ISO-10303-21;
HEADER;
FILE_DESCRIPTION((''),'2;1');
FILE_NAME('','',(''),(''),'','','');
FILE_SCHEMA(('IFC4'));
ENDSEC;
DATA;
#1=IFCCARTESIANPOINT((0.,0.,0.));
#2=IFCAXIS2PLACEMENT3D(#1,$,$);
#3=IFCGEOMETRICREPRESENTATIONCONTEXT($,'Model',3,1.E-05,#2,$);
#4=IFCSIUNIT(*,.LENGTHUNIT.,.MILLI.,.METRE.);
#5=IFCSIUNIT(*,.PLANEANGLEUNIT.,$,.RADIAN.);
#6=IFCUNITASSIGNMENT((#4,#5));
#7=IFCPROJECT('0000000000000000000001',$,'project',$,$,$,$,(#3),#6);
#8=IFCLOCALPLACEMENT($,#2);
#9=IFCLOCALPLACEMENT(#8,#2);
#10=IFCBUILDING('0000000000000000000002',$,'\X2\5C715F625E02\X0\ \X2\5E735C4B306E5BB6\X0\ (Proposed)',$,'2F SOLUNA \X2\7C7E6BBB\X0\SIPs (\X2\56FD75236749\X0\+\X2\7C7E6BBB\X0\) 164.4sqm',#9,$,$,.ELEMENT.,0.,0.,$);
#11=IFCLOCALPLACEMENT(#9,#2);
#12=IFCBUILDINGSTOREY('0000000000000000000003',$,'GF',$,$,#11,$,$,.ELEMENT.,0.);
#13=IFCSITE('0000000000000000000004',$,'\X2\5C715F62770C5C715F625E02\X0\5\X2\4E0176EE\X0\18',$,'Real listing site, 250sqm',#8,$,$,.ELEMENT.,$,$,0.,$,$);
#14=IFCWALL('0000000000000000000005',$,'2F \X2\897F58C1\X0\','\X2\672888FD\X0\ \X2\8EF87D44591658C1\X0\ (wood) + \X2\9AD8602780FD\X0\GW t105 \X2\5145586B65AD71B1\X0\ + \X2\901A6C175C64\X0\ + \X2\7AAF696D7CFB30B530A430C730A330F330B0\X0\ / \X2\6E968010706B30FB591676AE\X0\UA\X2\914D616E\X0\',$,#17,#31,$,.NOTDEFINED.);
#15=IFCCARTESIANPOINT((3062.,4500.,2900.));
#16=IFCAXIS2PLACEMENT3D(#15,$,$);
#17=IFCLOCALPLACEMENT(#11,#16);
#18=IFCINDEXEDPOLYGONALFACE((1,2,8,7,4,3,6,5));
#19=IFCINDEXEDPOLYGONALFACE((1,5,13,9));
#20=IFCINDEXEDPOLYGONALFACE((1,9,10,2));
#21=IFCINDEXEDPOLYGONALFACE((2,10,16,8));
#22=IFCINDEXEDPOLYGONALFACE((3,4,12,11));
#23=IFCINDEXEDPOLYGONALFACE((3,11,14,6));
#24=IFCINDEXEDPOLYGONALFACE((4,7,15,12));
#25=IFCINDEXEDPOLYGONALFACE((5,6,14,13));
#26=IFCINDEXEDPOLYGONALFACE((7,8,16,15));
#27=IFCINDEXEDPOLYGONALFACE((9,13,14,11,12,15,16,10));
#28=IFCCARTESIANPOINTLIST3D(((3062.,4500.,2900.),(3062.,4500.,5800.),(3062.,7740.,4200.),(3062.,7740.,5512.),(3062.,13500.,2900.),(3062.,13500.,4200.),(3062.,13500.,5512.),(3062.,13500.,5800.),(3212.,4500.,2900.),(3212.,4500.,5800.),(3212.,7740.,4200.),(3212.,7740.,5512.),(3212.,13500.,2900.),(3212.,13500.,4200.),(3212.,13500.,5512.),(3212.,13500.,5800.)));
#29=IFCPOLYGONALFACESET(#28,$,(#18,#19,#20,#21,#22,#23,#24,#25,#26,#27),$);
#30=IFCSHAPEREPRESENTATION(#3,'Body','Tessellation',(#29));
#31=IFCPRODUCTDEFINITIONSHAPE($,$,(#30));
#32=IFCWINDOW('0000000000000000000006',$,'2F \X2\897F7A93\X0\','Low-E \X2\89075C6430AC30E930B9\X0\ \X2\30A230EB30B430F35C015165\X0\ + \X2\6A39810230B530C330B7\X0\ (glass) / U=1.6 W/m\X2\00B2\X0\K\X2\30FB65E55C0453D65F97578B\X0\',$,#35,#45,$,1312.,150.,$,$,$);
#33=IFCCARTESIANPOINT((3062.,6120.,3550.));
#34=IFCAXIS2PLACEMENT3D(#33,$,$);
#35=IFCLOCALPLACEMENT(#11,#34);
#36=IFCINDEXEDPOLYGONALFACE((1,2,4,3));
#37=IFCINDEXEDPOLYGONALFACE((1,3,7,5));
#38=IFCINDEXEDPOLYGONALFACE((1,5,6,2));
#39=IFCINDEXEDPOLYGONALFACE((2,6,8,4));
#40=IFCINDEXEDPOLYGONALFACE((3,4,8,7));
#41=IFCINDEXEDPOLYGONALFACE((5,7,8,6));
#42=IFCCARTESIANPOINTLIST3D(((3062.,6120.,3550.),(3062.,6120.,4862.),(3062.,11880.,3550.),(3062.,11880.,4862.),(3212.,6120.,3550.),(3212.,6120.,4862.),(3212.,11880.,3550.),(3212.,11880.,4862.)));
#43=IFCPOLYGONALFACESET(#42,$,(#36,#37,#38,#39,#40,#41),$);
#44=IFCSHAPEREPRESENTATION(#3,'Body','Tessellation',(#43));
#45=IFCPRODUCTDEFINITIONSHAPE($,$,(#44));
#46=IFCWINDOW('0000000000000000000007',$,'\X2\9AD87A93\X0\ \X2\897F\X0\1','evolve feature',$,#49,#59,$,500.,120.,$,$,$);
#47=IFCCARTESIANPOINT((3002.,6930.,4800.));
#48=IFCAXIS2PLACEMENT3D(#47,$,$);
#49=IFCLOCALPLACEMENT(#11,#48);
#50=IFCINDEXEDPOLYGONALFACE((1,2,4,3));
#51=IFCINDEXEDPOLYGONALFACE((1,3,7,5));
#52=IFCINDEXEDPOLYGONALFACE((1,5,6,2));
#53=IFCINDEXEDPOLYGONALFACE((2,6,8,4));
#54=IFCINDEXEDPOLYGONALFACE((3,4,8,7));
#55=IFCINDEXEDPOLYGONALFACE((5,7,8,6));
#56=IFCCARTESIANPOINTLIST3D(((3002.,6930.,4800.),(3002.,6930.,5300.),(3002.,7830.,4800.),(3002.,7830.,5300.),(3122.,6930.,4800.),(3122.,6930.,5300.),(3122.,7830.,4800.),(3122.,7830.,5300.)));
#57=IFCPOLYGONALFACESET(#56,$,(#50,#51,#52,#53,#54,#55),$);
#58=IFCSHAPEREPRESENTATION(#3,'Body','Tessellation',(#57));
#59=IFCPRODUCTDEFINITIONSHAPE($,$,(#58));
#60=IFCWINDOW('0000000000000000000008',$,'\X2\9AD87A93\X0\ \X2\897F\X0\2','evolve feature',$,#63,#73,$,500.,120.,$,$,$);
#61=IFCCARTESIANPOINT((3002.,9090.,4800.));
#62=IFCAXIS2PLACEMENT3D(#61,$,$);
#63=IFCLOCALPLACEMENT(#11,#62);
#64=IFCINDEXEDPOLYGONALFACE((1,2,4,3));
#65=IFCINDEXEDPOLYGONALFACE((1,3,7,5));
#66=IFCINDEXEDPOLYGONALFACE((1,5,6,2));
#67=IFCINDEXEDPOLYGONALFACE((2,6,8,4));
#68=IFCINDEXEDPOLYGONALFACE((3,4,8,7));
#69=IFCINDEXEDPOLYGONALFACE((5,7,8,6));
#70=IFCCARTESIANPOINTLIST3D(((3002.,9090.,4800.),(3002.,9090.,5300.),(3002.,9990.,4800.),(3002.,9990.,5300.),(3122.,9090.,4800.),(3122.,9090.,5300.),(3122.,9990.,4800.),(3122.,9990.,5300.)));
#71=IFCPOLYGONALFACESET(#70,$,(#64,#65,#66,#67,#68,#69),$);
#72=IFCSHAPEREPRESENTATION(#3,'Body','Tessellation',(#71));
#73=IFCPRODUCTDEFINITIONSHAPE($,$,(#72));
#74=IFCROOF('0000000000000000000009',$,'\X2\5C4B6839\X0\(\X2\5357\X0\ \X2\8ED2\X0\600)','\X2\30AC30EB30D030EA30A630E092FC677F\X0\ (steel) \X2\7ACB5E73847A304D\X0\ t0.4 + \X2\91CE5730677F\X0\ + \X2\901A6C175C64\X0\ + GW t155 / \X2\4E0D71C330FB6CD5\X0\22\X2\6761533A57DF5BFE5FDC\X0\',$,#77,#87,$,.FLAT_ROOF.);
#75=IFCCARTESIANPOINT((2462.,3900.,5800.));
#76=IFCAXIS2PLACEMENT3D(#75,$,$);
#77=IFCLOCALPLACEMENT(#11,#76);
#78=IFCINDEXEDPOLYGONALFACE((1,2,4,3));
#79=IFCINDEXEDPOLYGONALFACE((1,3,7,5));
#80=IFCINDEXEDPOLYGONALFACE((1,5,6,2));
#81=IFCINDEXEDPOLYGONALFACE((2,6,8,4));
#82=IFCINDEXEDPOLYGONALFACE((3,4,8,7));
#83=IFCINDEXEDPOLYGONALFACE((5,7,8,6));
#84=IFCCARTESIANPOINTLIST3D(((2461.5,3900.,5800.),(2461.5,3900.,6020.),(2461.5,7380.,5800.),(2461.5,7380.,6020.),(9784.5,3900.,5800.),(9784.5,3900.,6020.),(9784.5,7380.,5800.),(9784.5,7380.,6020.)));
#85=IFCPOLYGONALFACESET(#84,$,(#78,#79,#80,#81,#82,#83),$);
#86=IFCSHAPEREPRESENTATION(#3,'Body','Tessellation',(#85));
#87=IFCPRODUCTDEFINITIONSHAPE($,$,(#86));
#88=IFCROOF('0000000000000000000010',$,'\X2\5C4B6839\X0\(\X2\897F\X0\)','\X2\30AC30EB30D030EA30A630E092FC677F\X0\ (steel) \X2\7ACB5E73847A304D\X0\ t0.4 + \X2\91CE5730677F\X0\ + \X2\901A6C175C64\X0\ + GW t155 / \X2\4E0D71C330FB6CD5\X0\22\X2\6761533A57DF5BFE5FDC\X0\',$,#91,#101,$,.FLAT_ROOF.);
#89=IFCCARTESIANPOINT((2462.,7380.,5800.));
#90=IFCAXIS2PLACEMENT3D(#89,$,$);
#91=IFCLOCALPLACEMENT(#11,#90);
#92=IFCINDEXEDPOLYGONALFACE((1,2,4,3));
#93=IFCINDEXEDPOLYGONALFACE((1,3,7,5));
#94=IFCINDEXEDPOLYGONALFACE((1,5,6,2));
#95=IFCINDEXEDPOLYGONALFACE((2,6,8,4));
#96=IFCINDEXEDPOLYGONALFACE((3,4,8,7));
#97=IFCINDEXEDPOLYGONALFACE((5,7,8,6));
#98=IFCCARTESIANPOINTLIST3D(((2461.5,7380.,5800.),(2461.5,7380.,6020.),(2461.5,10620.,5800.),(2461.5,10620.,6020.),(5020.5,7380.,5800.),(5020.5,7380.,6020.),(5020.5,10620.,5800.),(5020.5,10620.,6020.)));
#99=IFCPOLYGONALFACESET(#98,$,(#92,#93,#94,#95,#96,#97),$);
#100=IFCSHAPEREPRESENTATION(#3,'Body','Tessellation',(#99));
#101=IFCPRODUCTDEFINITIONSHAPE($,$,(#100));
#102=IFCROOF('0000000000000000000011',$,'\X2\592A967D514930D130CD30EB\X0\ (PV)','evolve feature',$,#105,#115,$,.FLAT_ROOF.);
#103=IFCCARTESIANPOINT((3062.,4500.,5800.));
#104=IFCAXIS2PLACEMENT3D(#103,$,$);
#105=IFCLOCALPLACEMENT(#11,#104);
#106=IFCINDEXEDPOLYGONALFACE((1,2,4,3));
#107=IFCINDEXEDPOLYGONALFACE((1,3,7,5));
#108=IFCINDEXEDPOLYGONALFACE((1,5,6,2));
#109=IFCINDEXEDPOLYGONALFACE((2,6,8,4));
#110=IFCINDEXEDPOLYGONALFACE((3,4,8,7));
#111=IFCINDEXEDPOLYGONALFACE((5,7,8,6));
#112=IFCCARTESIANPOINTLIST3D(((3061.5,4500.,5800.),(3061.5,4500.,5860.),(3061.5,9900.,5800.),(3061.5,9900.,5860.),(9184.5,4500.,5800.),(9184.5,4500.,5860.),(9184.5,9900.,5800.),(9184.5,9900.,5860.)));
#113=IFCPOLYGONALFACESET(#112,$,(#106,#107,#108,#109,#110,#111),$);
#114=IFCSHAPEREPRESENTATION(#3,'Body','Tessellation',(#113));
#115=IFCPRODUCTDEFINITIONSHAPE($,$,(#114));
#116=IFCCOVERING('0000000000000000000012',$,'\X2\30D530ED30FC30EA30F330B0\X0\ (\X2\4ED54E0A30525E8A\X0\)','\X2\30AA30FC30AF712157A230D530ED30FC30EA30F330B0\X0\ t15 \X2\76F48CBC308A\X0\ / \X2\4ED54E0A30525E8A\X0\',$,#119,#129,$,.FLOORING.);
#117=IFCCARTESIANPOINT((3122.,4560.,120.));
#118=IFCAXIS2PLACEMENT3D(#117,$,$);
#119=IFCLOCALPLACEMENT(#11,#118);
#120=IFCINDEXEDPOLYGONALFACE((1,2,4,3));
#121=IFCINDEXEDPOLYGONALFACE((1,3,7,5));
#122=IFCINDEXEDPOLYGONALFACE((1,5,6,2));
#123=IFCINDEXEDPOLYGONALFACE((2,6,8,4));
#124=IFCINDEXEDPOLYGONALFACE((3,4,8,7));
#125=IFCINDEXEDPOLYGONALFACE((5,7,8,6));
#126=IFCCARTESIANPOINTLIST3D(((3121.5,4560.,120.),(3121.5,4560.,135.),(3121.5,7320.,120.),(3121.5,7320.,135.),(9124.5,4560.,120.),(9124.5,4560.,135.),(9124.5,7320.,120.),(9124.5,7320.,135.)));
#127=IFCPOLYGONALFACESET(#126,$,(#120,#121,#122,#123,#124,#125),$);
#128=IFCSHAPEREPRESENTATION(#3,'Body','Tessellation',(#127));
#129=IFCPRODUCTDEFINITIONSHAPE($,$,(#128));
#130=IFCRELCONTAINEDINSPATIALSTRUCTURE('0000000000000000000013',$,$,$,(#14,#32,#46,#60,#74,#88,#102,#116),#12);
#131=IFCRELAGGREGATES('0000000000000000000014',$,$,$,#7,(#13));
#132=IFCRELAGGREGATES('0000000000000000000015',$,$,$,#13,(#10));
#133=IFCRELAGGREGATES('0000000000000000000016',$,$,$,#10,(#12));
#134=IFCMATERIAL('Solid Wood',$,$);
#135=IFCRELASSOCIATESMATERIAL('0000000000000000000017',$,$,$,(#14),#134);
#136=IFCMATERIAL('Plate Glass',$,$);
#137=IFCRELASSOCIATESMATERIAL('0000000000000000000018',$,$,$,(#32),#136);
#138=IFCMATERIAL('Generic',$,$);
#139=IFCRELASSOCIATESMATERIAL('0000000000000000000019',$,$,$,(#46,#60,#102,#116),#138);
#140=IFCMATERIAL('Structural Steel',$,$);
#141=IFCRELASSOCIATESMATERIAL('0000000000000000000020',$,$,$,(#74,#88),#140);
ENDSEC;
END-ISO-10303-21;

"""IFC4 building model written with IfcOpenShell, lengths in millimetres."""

from ifc_helpers import new_model, si_unit, frame, frame_2d, origin, place, context, project, spatial, rectangle, extrude, material, element, fill, save


model = new_model("IFC4")

# Units and contexts
model_context = context("Model", 3, precision=1e-05, world=origin())
ifc_project = project(units=[si_unit("LENGTHUNIT", "METRE", prefix="MILLI"), si_unit("PLANEANGLEUNIT", "RADIAN")], contexts=[model_context])

# Site, building, storey
site_placement = place(None, origin())
site = spatial("IfcSite", under=ifc_project, at=site_placement, Name="山形県山形市5丁目18", ObjectType="Real listing site, 250sqm", CompositionType="ELEMENT", RefElevation=0.0)
building_placement = place(site_placement, origin())
building = spatial("IfcBuilding", under=site, at=building_placement, Name="山形市 平屋の家 (Proposed)", ObjectType="2F SOLUNA 籾殻SIPs (国産杉+籾殻) 164.4sqm", CompositionType="ELEMENT", ElevationOfRefHeight=0.0, ElevationOfTerrain=0.0)
storey_placement = place(building_placement, origin())
storey = spatial("IfcBuildingStorey", under=building, at=storey_placement, Name="GF", CompositionType="ELEMENT", Elevation=0.0)

# Shared definitions
ifc_material_1 = material(Name="Solid Wood")
ifc_material_2 = material(Name="Generic")

# Shared definitions
ifc_material_3 = material(Name="Plate Glass")

# Wall, openings, windows
wall_1_placement = place(storey_placement, frame((3062.0, 4500.0, 2900.0)))
wall_1 = element("IfcWall", 1, at=wall_1_placement, inside=storey, material=ifc_material_1, Name="2F 西壁", Description="木製 軸組外壁 (wood) + 高性能GW t105 充填断熱 + 通気層 + 窯業系サイディング / 準耐火・外皮UA配慮", PredefinedType="NOTDEFINED", context=model_context, shape_type="SweptSolid", body=[
    extrude(rectangle(XDim=150.0, YDim=9000.0, at=frame_2d((75.0, 4500.0))), frame((3062.0, 4500.0, 2900.0)), (0.0, 0.0, 1.0), 2900.0),
])
opening_1_placement = place(storey_placement, frame((3062.0, 6120.0, 3550.0)))
opening_1 = element("IfcOpeningElement", 2, at=opening_1_placement, cuts=wall_1, PredefinedType="NOTDEFINED", context=model_context, shape_type="SweptSolid", body=[
    extrude(rectangle(XDim=150.0, YDim=5760.0, at=frame_2d((75.0, 2880.0))), frame((3062.0, 6120.0, 3550.0)), (0.0, 0.0, 1.0), 1312.0),
])
opening_2_placement = place(storey_placement, frame((3002.0, 6930.0, 4800.0)))
opening_2 = element("IfcOpeningElement", 3, at=opening_2_placement, cuts=wall_1, PredefinedType="NOTDEFINED", context=model_context, shape_type="SweptSolid", body=[
    extrude(rectangle(XDim=120.0, YDim=900.0, at=frame_2d((60.0, 450.0))), frame((3002.0, 6930.0, 4800.0)), (0.0, 0.0, 1.0), 500.0),
])
opening_3_placement = place(storey_placement, frame((3002.0, 9090.0, 4800.0)))
opening_3 = element("IfcOpeningElement", 4, at=opening_3_placement, cuts=wall_1, PredefinedType="NOTDEFINED", context=model_context, shape_type="SweptSolid", body=[
    extrude(rectangle(XDim=120.0, YDim=900.0, at=frame_2d((60.0, 450.0))), frame((3002.0, 9090.0, 4800.0)), (0.0, 0.0, 1.0), 500.0),
])
window_1_placement = place(storey_placement, frame((3062.0, 6120.0, 3550.0)))
window_1 = element("IfcWindow", 5, at=window_1_placement, inside=storey, material=ifc_material_3, Name="2F 西窓", Description="Low-E 複層ガラス アルゴン封入 + 樹脂サッシ (glass) / U=1.6 W/m²K・日射取得型", OverallHeight=1312.0, OverallWidth=150.0, context=model_context, shape_type="SweptSolid", body=[
    extrude(rectangle(XDim=150.0, YDim=5760.0, at=frame_2d((75.0, 2880.0))), frame((3062.0, 6120.0, 3550.0)), (0.0, 0.0, 1.0), 1312.0),
])
fill(opening_1, window_1)
window_2_placement = place(storey_placement, frame((3002.0, 6930.0, 4800.0)))
window_2 = element("IfcWindow", 6, at=window_2_placement, inside=storey, material=ifc_material_2, Name="高窓 西1", Description="evolve feature", OverallHeight=500.0, OverallWidth=120.0, context=model_context, shape_type="SweptSolid", body=[
    extrude(rectangle(XDim=120.0, YDim=900.0, at=frame_2d((60.0, 450.0))), frame((3002.0, 6930.0, 4800.0)), (0.0, 0.0, 1.0), 500.0),
])
fill(opening_2, window_2)
window_3_placement = place(storey_placement, frame((3002.0, 9090.0, 4800.0)))
window_3 = element("IfcWindow", 7, at=window_3_placement, inside=storey, material=ifc_material_2, Name="高窓 西2", Description="evolve feature", OverallHeight=500.0, OverallWidth=120.0, context=model_context, shape_type="SweptSolid", body=[
    extrude(rectangle(XDim=120.0, YDim=900.0, at=frame_2d((60.0, 450.0))), frame((3002.0, 9090.0, 4800.0)), (0.0, 0.0, 1.0), 500.0),
])
fill(opening_3, window_3)

# Roofs
ifc_material_4 = material(Name="Structural Steel")
roof_1_placement = place(storey_placement, frame((2462.0, 3900.0, 5800.0)))
element("IfcRoof", 8, at=roof_1_placement, inside=storey, material=ifc_material_4, Name="屋根(南 軒600)", Description="ガルバリウム鋼板 (steel) 立平葺き t0.4 + 野地板 + 通気層 + GW t155 / 不燃・法22条区域対応", PredefinedType="FLAT_ROOF", context=model_context, shape_type="SweptSolid", body=[
    extrude(rectangle(XDim=7323.0, YDim=3480.0, at=frame_2d((3661.0, 1740.0))), frame((2462.0, 3900.0, 5800.0)), (0.0, 0.0, 1.0), 220.0),
])
roof_2_placement = place(storey_placement, frame((2462.0, 7380.0, 5800.0)))
element("IfcRoof", 9, at=roof_2_placement, inside=storey, material=ifc_material_4, Name="屋根(西)", Description="ガルバリウム鋼板 (steel) 立平葺き t0.4 + 野地板 + 通気層 + GW t155 / 不燃・法22条区域対応", PredefinedType="FLAT_ROOF", context=model_context, shape_type="SweptSolid", body=[
    extrude(rectangle(XDim=2559.0, YDim=3240.0, at=frame_2d((1279.0, 1620.0))), frame((2462.0, 7380.0, 5800.0)), (0.0, 0.0, 1.0), 220.0),
])
roof_3_placement = place(storey_placement, frame((3062.0, 4500.0, 5800.0)))
element("IfcRoof", 10, at=roof_3_placement, inside=storey, material=ifc_material_2, Name="太陽光パネル (PV)", Description="evolve feature", PredefinedType="FLAT_ROOF", context=model_context, shape_type="SweptSolid", body=[
    extrude(rectangle(XDim=6123.0, YDim=5400.0, at=frame_2d((3061.0, 2700.0))), frame((3062.0, 4500.0, 5800.0)), (0.0, 0.0, 1.0), 60.0),
])

# Covering
covering_placement = place(storey_placement, frame((3122.0, 4560.0, 120.0)))
element("IfcCovering", 11, at=covering_placement, inside=storey, material=ifc_material_2, Name="フローリング (仕上げ床)", Description="オーク無垢フローリング t15 直貼り / 仕上げ床", PredefinedType="FLOORING", context=model_context, shape_type="SweptSolid", body=[
    extrude(rectangle(XDim=6003.0, YDim=2760.0, at=frame_2d((3001.0, 1380.0))), frame((3122.0, 4560.0, 120.0)), (0.0, 0.0, 1.0), 15.0),
])

save(model, "model.ifc")
